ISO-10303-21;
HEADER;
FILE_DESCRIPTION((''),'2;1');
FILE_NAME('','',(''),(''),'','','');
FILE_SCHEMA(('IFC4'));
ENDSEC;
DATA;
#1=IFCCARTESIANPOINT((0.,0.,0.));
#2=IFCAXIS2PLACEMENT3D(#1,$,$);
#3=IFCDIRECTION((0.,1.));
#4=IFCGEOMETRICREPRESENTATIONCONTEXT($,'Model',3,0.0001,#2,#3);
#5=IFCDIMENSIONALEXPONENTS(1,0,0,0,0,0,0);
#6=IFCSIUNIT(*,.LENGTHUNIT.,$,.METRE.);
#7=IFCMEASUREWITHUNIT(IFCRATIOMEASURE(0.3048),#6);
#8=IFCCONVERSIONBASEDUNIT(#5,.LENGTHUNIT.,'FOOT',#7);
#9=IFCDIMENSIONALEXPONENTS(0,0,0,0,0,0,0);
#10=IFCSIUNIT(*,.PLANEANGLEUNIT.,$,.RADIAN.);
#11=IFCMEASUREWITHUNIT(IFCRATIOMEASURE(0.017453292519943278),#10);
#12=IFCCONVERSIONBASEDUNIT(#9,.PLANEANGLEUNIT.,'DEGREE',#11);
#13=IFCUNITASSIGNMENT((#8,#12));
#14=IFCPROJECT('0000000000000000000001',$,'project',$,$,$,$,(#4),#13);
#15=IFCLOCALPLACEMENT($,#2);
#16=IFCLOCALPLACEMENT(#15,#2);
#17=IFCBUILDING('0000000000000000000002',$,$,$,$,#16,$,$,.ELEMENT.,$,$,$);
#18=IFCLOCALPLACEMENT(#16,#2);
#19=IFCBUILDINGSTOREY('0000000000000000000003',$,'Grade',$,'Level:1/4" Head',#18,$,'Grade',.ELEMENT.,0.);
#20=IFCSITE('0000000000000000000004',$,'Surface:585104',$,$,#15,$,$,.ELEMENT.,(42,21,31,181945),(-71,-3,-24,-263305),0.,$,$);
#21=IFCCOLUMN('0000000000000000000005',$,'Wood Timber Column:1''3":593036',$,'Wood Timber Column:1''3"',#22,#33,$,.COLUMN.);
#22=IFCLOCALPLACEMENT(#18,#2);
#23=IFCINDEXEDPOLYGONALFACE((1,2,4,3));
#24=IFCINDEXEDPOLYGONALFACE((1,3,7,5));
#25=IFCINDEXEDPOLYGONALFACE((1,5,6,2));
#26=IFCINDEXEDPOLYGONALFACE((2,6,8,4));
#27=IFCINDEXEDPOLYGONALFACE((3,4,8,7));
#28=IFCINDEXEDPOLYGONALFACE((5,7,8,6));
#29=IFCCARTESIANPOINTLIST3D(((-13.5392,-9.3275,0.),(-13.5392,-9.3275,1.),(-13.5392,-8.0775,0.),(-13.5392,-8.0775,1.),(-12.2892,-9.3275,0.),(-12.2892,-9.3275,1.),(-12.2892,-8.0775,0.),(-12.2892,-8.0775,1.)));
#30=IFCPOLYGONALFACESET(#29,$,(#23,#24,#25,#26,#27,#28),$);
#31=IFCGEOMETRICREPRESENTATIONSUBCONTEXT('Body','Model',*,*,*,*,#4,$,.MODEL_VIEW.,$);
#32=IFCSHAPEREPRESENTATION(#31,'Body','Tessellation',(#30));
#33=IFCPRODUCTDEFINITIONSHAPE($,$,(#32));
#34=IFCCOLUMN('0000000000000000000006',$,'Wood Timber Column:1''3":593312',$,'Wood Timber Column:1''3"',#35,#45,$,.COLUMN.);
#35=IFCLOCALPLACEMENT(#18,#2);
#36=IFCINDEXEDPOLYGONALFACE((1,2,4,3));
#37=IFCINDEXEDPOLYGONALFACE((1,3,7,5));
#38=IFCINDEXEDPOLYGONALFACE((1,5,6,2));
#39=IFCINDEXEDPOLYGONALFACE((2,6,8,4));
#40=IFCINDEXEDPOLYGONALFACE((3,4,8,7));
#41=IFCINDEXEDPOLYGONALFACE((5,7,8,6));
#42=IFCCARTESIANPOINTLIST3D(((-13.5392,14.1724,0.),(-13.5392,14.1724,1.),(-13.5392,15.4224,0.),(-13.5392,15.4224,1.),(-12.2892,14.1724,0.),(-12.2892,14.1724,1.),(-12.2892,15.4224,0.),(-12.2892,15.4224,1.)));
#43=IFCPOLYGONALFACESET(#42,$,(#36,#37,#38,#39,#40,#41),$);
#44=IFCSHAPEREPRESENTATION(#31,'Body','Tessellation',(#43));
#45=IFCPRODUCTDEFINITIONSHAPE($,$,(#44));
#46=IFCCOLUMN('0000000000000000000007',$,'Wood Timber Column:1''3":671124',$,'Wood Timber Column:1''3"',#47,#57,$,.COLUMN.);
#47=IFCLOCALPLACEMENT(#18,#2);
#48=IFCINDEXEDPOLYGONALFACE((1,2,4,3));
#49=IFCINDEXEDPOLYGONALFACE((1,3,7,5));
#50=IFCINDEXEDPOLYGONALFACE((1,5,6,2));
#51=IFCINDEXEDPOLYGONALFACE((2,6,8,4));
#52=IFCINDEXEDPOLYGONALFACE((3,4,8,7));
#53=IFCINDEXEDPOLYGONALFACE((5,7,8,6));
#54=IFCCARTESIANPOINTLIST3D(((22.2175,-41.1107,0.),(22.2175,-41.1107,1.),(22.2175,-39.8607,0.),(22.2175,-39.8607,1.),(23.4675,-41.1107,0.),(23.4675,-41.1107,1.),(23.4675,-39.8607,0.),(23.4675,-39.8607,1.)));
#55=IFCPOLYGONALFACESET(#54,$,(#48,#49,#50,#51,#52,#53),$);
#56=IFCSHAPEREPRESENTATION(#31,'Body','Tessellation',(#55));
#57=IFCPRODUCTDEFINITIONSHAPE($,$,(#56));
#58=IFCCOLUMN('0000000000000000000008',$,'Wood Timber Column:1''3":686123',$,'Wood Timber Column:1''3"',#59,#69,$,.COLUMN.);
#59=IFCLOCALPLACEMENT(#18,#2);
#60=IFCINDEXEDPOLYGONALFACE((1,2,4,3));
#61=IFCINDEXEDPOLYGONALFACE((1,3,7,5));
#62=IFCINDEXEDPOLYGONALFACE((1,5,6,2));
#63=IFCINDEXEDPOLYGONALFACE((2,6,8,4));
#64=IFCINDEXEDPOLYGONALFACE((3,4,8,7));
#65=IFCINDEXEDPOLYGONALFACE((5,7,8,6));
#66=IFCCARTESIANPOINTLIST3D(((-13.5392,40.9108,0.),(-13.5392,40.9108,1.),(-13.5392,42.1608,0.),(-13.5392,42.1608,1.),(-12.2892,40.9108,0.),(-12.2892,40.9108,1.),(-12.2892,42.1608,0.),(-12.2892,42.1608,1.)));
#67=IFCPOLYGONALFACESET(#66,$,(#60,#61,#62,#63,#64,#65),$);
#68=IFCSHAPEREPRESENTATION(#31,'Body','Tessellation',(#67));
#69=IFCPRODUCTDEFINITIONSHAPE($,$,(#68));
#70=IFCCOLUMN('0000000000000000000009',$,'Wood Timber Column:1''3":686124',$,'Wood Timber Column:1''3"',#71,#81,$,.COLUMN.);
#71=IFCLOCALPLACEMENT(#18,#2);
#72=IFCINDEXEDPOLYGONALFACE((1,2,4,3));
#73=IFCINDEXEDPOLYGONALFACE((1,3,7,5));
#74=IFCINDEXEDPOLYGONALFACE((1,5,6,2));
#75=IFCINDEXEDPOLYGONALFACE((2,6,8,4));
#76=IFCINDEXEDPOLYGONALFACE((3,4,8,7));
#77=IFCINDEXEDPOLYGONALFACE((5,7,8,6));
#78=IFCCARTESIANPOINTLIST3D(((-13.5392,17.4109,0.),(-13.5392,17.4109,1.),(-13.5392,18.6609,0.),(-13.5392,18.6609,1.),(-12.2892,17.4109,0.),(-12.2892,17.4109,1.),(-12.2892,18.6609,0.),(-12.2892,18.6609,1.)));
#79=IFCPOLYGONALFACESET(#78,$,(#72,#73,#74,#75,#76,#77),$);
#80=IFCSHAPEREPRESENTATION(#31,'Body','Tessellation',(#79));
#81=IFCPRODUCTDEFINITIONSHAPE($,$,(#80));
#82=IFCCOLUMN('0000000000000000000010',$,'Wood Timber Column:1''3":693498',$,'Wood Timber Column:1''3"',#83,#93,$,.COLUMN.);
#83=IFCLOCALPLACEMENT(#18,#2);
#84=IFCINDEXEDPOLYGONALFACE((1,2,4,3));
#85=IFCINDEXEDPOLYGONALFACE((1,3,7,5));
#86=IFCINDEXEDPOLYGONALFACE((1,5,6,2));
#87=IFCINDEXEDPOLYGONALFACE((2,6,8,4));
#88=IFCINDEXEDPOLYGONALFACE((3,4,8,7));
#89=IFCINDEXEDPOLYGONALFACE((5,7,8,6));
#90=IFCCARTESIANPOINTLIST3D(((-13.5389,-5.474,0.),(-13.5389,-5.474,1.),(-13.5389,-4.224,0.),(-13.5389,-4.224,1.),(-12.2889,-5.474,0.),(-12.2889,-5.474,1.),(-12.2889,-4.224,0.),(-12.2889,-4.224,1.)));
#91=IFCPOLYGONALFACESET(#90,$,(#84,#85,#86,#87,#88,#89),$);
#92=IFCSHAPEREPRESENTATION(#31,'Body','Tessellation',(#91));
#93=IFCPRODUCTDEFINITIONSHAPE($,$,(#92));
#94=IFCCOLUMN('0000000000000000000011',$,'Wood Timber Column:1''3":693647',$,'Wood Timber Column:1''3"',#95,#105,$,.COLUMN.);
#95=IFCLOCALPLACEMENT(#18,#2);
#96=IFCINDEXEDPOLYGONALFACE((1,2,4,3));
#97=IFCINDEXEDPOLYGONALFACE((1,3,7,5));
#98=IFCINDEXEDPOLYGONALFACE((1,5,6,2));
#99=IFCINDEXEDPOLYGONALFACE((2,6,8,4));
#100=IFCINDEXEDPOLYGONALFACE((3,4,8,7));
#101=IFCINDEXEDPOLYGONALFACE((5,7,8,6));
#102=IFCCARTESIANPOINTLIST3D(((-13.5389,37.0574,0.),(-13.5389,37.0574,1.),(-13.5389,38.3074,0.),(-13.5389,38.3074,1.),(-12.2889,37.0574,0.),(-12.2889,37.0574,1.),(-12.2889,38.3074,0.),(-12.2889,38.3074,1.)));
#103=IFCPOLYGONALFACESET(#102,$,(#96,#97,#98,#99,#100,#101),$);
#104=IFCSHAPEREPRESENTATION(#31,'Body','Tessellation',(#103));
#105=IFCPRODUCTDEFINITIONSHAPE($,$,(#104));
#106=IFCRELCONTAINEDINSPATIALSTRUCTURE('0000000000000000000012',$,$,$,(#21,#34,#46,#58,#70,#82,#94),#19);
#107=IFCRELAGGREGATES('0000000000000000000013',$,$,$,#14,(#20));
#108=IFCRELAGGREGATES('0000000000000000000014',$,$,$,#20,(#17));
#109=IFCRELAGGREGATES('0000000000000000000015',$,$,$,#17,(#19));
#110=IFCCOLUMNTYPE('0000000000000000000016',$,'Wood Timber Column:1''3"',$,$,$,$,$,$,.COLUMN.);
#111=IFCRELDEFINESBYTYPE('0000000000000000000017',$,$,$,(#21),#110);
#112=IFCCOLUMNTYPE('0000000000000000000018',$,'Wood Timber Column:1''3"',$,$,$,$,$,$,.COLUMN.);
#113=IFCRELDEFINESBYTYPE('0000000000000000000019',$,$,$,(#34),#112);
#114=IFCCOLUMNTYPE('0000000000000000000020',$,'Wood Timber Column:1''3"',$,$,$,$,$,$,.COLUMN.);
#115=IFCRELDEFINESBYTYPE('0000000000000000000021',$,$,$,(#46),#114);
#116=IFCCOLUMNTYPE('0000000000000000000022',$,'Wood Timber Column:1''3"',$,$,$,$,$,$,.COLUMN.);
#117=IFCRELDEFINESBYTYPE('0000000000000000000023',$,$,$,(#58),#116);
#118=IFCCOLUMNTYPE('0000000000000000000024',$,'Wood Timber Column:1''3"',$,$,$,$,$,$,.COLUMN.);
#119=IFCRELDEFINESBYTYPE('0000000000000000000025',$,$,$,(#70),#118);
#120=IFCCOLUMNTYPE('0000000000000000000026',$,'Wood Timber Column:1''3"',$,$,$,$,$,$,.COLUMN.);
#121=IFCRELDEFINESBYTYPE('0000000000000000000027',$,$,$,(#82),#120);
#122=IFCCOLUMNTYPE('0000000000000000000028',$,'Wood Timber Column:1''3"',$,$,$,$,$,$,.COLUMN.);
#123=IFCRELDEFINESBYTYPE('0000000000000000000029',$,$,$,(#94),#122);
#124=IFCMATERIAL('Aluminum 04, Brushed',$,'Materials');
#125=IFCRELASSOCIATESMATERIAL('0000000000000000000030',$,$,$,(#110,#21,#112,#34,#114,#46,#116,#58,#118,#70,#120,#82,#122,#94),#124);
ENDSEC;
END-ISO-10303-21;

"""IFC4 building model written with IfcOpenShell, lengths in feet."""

from ifc_helpers import new_model, entity, si_unit, converted_unit, direction, frame, origin, place, context, subcontext, project, spatial, indexed_curve, outline, extrude, source, transform, mapped, material, type_object, type_shapes, element, save


model = new_model("IFC4")

# Units and contexts
model_context = context("Model", 3, precision=0.0001, world=origin(), true_north=direction((0.0, 1.0)))
body_context = subcontext(model_context, "Body", "Model", "MODEL_VIEW")
ifc_project = project(units=[converted_unit("LENGTHUNIT", "FOOT", entity("IfcRatioMeasure", 0.3048), si_unit("LENGTHUNIT", "METRE"), dimensions=[1, 0, 0, 0, 0, 0, 0]), converted_unit("PLANEANGLEUNIT", "DEGREE", entity("IfcRatioMeasure", 0.017453292519943278), si_unit("PLANEANGLEUNIT", "RADIAN"), dimensions=[0, 0, 0, 0, 0, 0, 0])], contexts=[model_context])

# Site, building, storey
site_placement = place(None, origin())
site = spatial("IfcSite", under=ifc_project, at=site_placement, Name="Surface:585104", CompositionType="ELEMENT", RefLatitude=(42, 21, 31, 181945), RefLongitude=(-71, -3, -24, -263305), RefElevation=0.0)
building_placement = place(site_placement, origin())
building = spatial("IfcBuilding", under=site, at=building_placement, CompositionType="ELEMENT")
storey_placement = place(building_placement, origin())
storey = spatial("IfcBuildingStorey", under=building, at=storey_placement, Name="Grade", ObjectType="Level:1/4\" Head", LongName="Grade", CompositionType="ELEMENT", Elevation=0.0)

# Columns
ifc_material = material(Name="Aluminum 04, Brushed", Category="Materials")
column_type_1 = type_object("IfcColumnType", Name="Wood Timber Column:1'3\"", PredefinedType="COLUMN", material=ifc_material)
shared_shape_1 = source(origin(), body_context, "Body", "SweptSolid", [
    extrude(outline(indexed_curve([(-0.625, -0.625), (0.625, -0.625), (0.625, 0.625), (-0.625, 0.625), (-0.625, -0.625)], self_intersect=False)), frame((-12.9142, -8.7025, 0.0), z_axis=(0.0, 0.0, 1.0), x_axis=(0.0, -1.0, 0.0)), (0.0, 0.0, 1.0), 1.0),
])
type_shapes(column_type_1, [shared_shape_1])
column_1_placement = place(storey_placement, origin())
element("IfcColumn", 1, at=column_1_placement, inside=storey, type_object=column_type_1, material=ifc_material, Name="Wood Timber Column:1'3\":593036", ObjectType="Wood Timber Column:1'3\"", PredefinedType="COLUMN", context=body_context, shape_type="MappedRepresentation", body=[
    mapped(shared_shape_1, transform((0.0, 0.0, 0.0), scale=1.0)),
])
column_type_2 = type_object("IfcColumnType", Name="Wood Timber Column:1'3\"", PredefinedType="COLUMN", material=ifc_material)
shared_shape_2 = source(origin(), body_context, "Body", "SweptSolid", [
    extrude(outline(indexed_curve([(-0.625, -0.625), (0.625, -0.625), (0.625, 0.625), (-0.625, 0.625), (-0.625, -0.625)], self_intersect=False)), frame((-12.9142, 14.7974, 0.0), z_axis=(0.0, 0.0, 1.0), x_axis=(0.0, -1.0, 0.0)), (0.0, 0.0, 1.0), 1.0),
])
type_shapes(column_type_2, [shared_shape_2])
column_2_placement = place(storey_placement, origin())
element("IfcColumn", 2, at=column_2_placement, inside=storey, type_object=column_type_2, material=ifc_material, Name="Wood Timber Column:1'3\":593312", ObjectType="Wood Timber Column:1'3\"", PredefinedType="COLUMN", context=body_context, shape_type="MappedRepresentation", body=[
    mapped(shared_shape_2, transform((0.0, 0.0, 0.0), scale=1.0)),
])
column_type_3 = type_object("IfcColumnType", Name="Wood Timber Column:1'3\"", PredefinedType="COLUMN", material=ifc_material)
shared_shape_3 = source(origin(), body_context, "Body", "SweptSolid", [
    extrude(outline(indexed_curve([(-0.625, -0.625), (0.625, -0.625), (0.625, 0.625), (-0.625, 0.625), (-0.625, -0.625)], self_intersect=False)), frame((22.8425, -40.4857, 0.0), z_axis=(0.0, 0.0, 1.0), x_axis=(0.0, -1.0, 0.0)), (0.0, 0.0, 1.0), 1.0),
])
type_shapes(column_type_3, [shared_shape_3])
column_3_placement = place(storey_placement, origin())
element("IfcColumn", 3, at=column_3_placement, inside=storey, type_object=column_type_3, material=ifc_material, Name="Wood Timber Column:1'3\":671124", ObjectType="Wood Timber Column:1'3\"", PredefinedType="COLUMN", context=body_context, shape_type="MappedRepresentation", body=[
    mapped(shared_shape_3, transform((0.0, 0.0, 0.0), scale=1.0)),
])
column_type_4 = type_object("IfcColumnType", Name="Wood Timber Column:1'3\"", PredefinedType="COLUMN", material=ifc_material)
shared_shape_4 = source(origin(), body_context, "Body", "SweptSolid", [
    extrude(outline(indexed_curve([(-0.625, -0.625), (0.625, -0.625), (0.625, 0.625), (-0.625, 0.625), (-0.625, -0.625)], self_intersect=False)), frame((-12.9142, 41.5358, 0.0), z_axis=(0.0, 0.0, 1.0), x_axis=(0.0, -1.0, 0.0)), (0.0, 0.0, 1.0), 1.0),
])
type_shapes(column_type_4, [shared_shape_4])
column_4_placement = place(storey_placement, origin())
element("IfcColumn", 4, at=column_4_placement, inside=storey, type_object=column_type_4, material=ifc_material, Name="Wood Timber Column:1'3\":686123", ObjectType="Wood Timber Column:1'3\"", PredefinedType="COLUMN", context=body_context, shape_type="MappedRepresentation", body=[
    mapped(shared_shape_4, transform((0.0, 0.0, 0.0), scale=1.0)),
])
column_type_5 = type_object("IfcColumnType", Name="Wood Timber Column:1'3\"", PredefinedType="COLUMN", material=ifc_material)
shared_shape_5 = source(origin(), body_context, "Body", "SweptSolid", [
    extrude(outline(indexed_curve([(-0.625, -0.625), (0.625, -0.625), (0.625, 0.625), (-0.625, 0.625), (-0.625, -0.625)], self_intersect=False)), frame((-12.9142, 18.0359, 0.0), z_axis=(0.0, 0.0, 1.0), x_axis=(0.0, -1.0, 0.0)), (0.0, 0.0, 1.0), 1.0),
])
type_shapes(column_type_5, [shared_shape_5])
column_5_placement = place(storey_placement, origin())
element("IfcColumn", 5, at=column_5_placement, inside=storey, type_object=column_type_5, material=ifc_material, Name="Wood Timber Column:1'3\":686124", ObjectType="Wood Timber Column:1'3\"", PredefinedType="COLUMN", context=body_context, shape_type="MappedRepresentation", body=[
    mapped(shared_shape_5, transform((0.0, 0.0, 0.0), scale=1.0)),
])
column_type_6 = type_object("IfcColumnType", Name="Wood Timber Column:1'3\"", PredefinedType="COLUMN", material=ifc_material)
shared_shape_6 = source(origin(), body_context, "Body", "SweptSolid", [
    extrude(outline(indexed_curve([(-0.625, -0.625), (0.625, -0.625), (0.625, 0.625), (-0.625, 0.625), (-0.625, -0.625)], self_intersect=False)), frame((-12.9139, -4.849, 0.0), z_axis=(0.0, 0.0, 1.0), x_axis=(0.0, -1.0, 0.0)), (0.0, 0.0, 1.0), 1.0),
])
type_shapes(column_type_6, [shared_shape_6])
column_6_placement = place(storey_placement, origin())
element("IfcColumn", 6, at=column_6_placement, inside=storey, type_object=column_type_6, material=ifc_material, Name="Wood Timber Column:1'3\":693498", ObjectType="Wood Timber Column:1'3\"", PredefinedType="COLUMN", context=body_context, shape_type="MappedRepresentation", body=[
    mapped(shared_shape_6, transform((0.0, 0.0, 0.0), scale=1.0)),
])
column_type_7 = type_object("IfcColumnType", Name="Wood Timber Column:1'3\"", PredefinedType="COLUMN", material=ifc_material)
shared_shape_7 = source(origin(), body_context, "Body", "SweptSolid", [
    extrude(outline(indexed_curve([(-0.625, -0.625), (0.625, -0.625), (0.625, 0.625), (-0.625, 0.625), (-0.625, -0.625)], self_intersect=False)), frame((-12.9139, 37.6824, 0.0), z_axis=(0.0, 0.0, 1.0), x_axis=(0.0, -1.0, 0.0)), (0.0, 0.0, 1.0), 1.0),
])
type_shapes(column_type_7, [shared_shape_7])
column_7_placement = place(storey_placement, origin())
element("IfcColumn", 7, at=column_7_placement, inside=storey, type_object=column_type_7, material=ifc_material, Name="Wood Timber Column:1'3\":693647", ObjectType="Wood Timber Column:1'3\"", PredefinedType="COLUMN", context=body_context, shape_type="MappedRepresentation", body=[
    mapped(shared_shape_7, transform((0.0, 0.0, 0.0), scale=1.0)),
])

save(model, "model.ifc")
